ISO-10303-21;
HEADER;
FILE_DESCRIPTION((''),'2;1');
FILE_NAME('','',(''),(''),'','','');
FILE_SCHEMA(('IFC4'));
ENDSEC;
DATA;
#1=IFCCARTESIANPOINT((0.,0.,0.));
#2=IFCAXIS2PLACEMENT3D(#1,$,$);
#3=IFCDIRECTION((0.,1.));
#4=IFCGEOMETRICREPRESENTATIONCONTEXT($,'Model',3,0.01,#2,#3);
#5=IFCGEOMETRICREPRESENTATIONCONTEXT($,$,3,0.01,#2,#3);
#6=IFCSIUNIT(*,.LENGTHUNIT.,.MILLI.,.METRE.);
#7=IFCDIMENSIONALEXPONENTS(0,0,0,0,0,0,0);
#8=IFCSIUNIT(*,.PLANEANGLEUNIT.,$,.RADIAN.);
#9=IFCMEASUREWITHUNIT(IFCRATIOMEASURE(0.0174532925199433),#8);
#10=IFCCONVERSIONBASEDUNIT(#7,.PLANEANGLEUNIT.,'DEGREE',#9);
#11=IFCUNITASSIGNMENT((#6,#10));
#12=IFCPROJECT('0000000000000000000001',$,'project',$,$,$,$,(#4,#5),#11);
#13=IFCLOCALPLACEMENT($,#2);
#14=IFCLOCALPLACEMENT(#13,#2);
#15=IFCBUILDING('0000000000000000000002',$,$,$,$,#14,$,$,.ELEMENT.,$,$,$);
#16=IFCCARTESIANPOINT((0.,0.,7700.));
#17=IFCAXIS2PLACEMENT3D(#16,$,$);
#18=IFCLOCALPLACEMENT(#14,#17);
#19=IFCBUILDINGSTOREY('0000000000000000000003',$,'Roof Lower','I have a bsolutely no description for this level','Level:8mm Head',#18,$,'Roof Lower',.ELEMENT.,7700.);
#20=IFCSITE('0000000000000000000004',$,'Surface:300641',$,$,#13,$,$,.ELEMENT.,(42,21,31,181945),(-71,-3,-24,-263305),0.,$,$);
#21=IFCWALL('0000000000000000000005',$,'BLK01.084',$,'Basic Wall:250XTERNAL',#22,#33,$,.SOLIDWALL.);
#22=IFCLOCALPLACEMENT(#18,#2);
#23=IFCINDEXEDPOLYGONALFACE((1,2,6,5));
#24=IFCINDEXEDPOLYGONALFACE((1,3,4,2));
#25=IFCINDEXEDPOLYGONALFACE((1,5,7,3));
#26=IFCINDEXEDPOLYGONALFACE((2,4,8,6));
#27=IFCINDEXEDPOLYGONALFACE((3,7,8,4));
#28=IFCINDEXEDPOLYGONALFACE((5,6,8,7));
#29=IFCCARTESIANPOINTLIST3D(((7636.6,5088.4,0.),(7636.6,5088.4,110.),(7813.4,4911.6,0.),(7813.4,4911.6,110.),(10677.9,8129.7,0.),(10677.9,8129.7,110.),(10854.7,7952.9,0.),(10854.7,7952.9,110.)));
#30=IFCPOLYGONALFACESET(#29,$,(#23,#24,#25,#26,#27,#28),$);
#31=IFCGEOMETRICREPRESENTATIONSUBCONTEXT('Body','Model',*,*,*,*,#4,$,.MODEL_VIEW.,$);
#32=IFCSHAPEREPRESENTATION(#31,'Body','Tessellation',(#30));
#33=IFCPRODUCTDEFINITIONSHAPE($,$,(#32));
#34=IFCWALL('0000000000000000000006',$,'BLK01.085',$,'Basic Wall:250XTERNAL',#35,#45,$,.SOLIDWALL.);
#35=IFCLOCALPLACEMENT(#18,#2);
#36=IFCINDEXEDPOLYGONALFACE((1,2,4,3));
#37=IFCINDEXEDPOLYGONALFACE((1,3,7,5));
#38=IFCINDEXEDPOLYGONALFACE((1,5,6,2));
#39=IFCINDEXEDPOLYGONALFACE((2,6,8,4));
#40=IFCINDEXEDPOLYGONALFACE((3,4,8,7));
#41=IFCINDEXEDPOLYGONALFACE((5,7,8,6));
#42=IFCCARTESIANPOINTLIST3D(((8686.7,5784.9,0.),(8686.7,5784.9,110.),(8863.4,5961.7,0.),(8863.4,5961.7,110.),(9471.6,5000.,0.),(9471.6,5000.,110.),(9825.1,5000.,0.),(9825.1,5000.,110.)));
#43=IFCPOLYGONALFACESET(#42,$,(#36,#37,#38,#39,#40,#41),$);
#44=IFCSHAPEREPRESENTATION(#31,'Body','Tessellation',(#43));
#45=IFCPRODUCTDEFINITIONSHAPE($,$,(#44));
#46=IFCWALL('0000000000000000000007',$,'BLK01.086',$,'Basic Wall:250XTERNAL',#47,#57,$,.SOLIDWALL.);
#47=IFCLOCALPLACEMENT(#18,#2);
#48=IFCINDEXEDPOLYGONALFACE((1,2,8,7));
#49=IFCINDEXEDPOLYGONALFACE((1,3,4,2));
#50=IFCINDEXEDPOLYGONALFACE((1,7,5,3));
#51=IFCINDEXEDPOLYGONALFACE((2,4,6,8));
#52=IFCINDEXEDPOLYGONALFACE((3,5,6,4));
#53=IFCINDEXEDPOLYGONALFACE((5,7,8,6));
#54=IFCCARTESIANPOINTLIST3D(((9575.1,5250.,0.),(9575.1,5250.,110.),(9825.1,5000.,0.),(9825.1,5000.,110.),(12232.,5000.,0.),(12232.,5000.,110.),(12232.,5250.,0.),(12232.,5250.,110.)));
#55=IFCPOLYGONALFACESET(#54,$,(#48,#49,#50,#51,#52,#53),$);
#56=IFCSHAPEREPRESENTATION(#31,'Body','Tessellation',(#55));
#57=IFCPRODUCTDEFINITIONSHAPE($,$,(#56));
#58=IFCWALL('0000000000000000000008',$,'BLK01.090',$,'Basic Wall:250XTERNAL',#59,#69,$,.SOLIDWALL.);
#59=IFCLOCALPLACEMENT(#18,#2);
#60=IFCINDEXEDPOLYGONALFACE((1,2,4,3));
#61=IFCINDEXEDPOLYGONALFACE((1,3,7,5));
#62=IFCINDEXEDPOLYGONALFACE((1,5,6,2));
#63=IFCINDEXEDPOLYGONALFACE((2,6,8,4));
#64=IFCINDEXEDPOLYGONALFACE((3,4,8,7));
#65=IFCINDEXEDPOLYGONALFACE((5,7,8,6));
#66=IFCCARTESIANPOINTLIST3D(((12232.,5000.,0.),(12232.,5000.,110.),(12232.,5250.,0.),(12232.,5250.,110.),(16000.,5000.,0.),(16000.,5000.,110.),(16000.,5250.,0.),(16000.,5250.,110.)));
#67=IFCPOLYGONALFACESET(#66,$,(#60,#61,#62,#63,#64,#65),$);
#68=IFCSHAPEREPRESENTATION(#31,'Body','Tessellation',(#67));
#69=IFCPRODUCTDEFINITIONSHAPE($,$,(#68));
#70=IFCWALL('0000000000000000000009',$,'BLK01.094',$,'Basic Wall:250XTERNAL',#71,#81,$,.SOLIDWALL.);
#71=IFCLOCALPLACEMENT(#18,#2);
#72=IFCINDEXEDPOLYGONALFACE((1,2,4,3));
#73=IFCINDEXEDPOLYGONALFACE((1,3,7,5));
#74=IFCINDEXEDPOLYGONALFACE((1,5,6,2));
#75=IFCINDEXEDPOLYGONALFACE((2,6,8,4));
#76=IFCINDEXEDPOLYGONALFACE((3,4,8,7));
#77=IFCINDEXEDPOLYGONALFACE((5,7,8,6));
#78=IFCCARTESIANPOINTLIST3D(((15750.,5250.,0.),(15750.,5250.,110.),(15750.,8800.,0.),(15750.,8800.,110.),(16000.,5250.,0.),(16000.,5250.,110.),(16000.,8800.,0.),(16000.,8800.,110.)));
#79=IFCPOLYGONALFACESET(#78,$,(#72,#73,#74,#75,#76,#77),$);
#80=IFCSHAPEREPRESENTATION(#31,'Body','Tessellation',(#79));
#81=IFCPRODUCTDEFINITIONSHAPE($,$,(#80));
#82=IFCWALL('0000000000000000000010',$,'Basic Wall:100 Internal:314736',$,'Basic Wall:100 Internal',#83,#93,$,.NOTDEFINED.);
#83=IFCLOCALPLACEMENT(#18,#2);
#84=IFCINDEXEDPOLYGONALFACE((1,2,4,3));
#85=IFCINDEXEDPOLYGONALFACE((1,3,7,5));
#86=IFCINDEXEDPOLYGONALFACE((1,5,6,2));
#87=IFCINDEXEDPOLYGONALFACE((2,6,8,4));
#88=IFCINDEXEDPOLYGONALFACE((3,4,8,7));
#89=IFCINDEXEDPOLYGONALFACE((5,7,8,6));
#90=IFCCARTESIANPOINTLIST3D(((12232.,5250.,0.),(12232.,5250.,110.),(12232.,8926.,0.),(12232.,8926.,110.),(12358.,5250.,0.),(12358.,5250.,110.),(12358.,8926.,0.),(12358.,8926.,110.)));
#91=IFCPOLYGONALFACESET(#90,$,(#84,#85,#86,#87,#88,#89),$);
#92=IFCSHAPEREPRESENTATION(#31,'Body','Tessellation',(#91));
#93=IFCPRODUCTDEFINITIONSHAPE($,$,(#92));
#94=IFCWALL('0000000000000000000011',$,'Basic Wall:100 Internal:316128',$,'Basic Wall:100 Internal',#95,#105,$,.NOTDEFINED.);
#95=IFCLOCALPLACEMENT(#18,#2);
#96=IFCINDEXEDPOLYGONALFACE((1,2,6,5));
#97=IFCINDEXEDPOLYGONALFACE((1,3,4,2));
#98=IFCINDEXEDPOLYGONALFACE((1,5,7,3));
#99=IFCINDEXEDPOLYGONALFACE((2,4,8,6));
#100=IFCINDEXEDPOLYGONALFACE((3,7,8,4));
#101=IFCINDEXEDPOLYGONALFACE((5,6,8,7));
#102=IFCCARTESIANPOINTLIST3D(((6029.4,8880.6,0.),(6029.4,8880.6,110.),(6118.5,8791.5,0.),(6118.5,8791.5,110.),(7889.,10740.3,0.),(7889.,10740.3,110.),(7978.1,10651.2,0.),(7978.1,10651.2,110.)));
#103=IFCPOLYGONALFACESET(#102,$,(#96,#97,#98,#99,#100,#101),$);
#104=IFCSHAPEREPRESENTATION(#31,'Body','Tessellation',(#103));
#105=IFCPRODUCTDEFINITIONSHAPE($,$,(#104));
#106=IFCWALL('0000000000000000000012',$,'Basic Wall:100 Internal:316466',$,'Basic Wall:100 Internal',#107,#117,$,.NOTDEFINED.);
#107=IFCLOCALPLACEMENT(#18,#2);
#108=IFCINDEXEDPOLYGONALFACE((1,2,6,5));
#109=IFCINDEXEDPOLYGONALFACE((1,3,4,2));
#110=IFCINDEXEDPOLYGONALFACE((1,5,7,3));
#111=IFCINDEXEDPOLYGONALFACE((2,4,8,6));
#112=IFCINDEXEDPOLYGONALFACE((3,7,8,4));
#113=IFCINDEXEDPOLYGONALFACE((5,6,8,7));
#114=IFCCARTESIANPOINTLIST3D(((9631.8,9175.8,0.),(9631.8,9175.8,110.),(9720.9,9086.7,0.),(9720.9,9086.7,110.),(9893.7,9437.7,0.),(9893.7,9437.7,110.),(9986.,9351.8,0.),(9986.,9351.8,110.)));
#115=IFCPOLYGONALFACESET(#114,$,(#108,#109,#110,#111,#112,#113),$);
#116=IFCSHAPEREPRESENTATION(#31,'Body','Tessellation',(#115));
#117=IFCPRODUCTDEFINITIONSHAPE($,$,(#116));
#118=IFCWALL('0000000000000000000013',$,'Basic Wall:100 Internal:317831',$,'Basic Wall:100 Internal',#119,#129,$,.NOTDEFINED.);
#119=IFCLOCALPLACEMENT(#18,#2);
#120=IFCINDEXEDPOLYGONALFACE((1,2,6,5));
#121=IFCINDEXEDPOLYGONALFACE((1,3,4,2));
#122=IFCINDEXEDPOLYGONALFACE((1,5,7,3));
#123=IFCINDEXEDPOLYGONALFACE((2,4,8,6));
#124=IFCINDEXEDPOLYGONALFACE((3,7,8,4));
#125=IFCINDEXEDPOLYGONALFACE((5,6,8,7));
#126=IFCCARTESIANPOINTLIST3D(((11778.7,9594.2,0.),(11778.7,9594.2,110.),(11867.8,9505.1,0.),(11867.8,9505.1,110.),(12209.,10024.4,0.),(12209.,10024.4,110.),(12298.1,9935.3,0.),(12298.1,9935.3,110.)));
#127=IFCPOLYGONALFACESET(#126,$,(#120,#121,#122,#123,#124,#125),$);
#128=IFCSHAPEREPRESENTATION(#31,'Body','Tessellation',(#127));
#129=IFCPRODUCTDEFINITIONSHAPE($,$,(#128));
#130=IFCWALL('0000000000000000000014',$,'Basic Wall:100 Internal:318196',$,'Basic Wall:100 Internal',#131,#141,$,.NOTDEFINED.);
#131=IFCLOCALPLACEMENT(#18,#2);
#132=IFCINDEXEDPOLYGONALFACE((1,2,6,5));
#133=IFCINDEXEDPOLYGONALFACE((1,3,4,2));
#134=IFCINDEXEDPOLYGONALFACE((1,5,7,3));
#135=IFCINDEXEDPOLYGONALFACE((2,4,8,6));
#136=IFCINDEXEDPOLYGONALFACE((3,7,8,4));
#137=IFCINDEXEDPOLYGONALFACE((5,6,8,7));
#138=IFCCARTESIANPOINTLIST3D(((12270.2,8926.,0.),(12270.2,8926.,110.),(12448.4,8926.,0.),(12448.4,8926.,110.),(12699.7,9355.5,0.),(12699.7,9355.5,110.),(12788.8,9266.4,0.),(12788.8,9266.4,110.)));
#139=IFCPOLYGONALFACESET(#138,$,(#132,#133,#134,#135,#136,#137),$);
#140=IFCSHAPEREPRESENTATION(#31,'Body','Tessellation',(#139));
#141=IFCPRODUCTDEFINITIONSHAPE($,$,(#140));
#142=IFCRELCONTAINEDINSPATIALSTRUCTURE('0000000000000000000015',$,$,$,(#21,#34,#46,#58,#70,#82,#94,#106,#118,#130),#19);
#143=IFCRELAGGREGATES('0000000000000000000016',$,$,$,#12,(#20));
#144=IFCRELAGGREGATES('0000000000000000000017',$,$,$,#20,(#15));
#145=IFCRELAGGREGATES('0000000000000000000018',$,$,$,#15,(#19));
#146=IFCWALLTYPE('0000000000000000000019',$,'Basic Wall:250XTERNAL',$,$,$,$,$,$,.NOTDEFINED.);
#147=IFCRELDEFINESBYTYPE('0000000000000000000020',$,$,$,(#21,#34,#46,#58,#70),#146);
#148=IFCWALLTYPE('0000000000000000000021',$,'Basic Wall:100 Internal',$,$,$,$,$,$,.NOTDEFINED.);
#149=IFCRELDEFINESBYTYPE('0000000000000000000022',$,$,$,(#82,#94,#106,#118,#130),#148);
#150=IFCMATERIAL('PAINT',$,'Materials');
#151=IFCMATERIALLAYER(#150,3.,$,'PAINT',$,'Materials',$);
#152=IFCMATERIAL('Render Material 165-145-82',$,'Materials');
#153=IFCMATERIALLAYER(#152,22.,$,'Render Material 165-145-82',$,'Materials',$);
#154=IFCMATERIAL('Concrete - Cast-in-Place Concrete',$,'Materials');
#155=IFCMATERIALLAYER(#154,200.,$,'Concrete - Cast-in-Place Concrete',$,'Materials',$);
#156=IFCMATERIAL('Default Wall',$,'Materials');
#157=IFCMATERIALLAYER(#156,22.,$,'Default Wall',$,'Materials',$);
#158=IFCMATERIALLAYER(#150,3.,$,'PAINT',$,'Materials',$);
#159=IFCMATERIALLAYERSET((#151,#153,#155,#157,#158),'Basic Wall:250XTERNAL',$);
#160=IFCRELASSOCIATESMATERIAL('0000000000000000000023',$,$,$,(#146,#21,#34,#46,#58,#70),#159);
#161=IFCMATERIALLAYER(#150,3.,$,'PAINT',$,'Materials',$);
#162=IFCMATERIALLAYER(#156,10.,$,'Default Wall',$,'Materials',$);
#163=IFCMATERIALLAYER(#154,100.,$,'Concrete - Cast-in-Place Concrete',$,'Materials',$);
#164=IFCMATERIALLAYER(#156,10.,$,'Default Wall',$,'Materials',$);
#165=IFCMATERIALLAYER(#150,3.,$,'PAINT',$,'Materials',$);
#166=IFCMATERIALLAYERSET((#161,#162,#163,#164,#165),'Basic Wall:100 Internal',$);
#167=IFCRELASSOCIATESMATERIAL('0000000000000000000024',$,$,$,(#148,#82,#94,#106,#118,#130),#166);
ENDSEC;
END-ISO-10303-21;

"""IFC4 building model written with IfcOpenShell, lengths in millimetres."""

from ifc_helpers import new_model, entity, si_unit, converted_unit, direction, frame, frame_2d, origin, place, context, subcontext, project, spatial, polyline, rectangle, outline, extrude, clip, halfspace, bounded_halfspace, material, layer, layer_set, layer_usage, type_object, element, save


model = new_model("IFC4")

# Units and contexts
model_context = context("Model", 3, precision=0.01, world=origin(), true_north=direction((0.0, 1.0)))
context_of_model = context(None, 3, precision=0.01, world=origin(), true_north=direction((0.0, 1.0)))
body_context = subcontext(model_context, "Body", "Model", "MODEL_VIEW")
ifc_project = project(units=[si_unit("LENGTHUNIT", "METRE", prefix="MILLI"), converted_unit("PLANEANGLEUNIT", "DEGREE", entity("IfcRatioMeasure", 0.0174532925199433), si_unit("PLANEANGLEUNIT", "RADIAN"), dimensions=[0, 0, 0, 0, 0, 0, 0])], contexts=[model_context, context_of_model])

# Site, building, storey
site_placement = place(None, origin())
site = spatial("IfcSite", under=ifc_project, at=site_placement, Name="Surface:300641", CompositionType="ELEMENT", RefLatitude=(42, 21, 31, 181945), RefLongitude=(-71, -3, -24, -263305), RefElevation=0.0)
building_placement = place(site_placement, origin())
building = spatial("IfcBuilding", under=site, at=building_placement, CompositionType="ELEMENT")
storey_placement = place(building_placement, frame((0.0, 0.0, 7700.0)))
storey = spatial("IfcBuildingStorey", under=building, at=storey_placement, Name="Roof Lower", Description="I have a bsolutely no description for this level", ObjectType="Level:8mm Head", LongName="Roof Lower", CompositionType="ELEMENT", Elevation=7700.0)

# Shared definitions
ifc_material_1 = material(Name="Concrete - Cast-in-Place Concrete", Category="Materials")

# Walls
ifc_material_2 = material(Name="PAINT", Category="Materials")
ifc_layer_1 = layer(ifc_material_2, 3.0, Name="PAINT", Category="Materials")
ifc_material_3 = material(Name="Render Material 165-145-82", Category="Materials")
ifc_layer_2 = layer(ifc_material_3, 22.0, Name="Render Material 165-145-82", Category="Materials")
ifc_layer_3 = layer(ifc_material_1, 200.0, Name="Concrete - Cast-in-Place Concrete", Category="Materials")
ifc_material_4 = material(Name="Default Wall", Category="Materials")
ifc_layer_4 = layer(ifc_material_4, 22.0, Name="Default Wall", Category="Materials")
ifc_layer_5 = layer(ifc_material_2, 3.0, Name="PAINT", Category="Materials")
ifc_layer_set_1 = layer_set([ifc_layer_1, ifc_layer_2, ifc_layer_3, ifc_layer_4, ifc_layer_5], Name="Basic Wall:250XTERNAL")
ifc_layer_usage_1 = layer_usage(ifc_layer_set_1, "AXIS2", "NEGATIVE", 125.0)
wall_type_1 = type_object("IfcWallType", Name="Basic Wall:250XTERNAL", PredefinedType="NOTDEFINED", material=ifc_layer_set_1)
wall_1_placement = place(storey_placement, frame((7725.0, 5000.0, 0.0), z_axis=(0.0, 0.0, 1.0), x_axis=(0.707107, 0.707107, 0.0)))
element("IfcWall", 1, at=wall_1_placement, inside=storey, type_object=wall_type_1, material=ifc_layer_usage_1, Name="BLK01.084", ObjectType="Basic Wall:250XTERNAL", PredefinedType="SOLIDWALL", context=body_context, shape_type="Clipping", body=[
    clip(clip(extrude(rectangle(XDim=4301.0, YDim=250.0, at=frame_2d((2150.5, 0.0), x_axis=(-1.0, 0.0))), origin(), (0.0, 0.0, 1.0), 110.0), bounded_halfspace(frame((0.0, -125.0, 110.0), z_axis=(0.0, 0.0, -1.0), x_axis=(0.707107, -0.707107, 0.0)), True, frame((0.0, -125.0, 110.0)), polyline([(0.0, 0.0), (1235.0, 0.0), (1485.0, 0.0), (3527.0, 0.0), (3653.0, 0.0), (4301.0, 0.0), (4301.0, 250.0), (4175.0, 250.0), (0.0, 250.0), (0.0, 0.0)]))), halfspace(frame((0.0, 0.0, -3500.0)), True)),
])
ifc_layer_usage_2 = layer_usage(ifc_layer_set_1, "AXIS2", "NEGATIVE", 125.0)
wall_2_placement = place(storey_placement, frame((8775.1, 5873.3, 0.0), z_axis=(0.0, 0.0, 1.0), x_axis=(0.707107, -0.707107, 0.0)))
element("IfcWall", 2, at=wall_2_placement, inside=storey, type_object=wall_type_1, material=ifc_layer_usage_2, Name="BLK01.085", ObjectType="Basic Wall:250XTERNAL", PredefinedType="SOLIDWALL", context=body_context, shape_type="Clipping", body=[
    clip(clip(extrude(outline(polyline([(1110.0, -125.0), (1360.0, 125.0), (1006.4, 125.0), (0.0, 125.0), (0.0, -125.0), (1110.0, -125.0)])), origin(), (0.0, 0.0, 1.0), 110.0), bounded_halfspace(frame((0.0, -125.0, 110.0), z_axis=(0.0, 0.0, -1.0), x_axis=(0.707107, 0.707107, 0.0)), True, frame((0.0, -125.0, 110.0)), polyline([(0.0, 0.0), (1110.0, 0.0), (1360.0, 250.0), (1006.4, 250.0), (0.0, 250.0), (0.0, 0.0)]))), halfspace(frame((0.0, 0.0, -3500.0)), True)),
])
ifc_layer_usage_3 = layer_usage(ifc_layer_set_1, "AXIS2", "NEGATIVE", 125.0)
wall_3_placement = place(storey_placement, frame((9575.1, 5125.0, 0.0)))
element("IfcWall", 3, at=wall_3_placement, inside=storey, type_object=wall_type_1, material=ifc_layer_usage_3, Name="BLK01.086", ObjectType="Basic Wall:250XTERNAL", PredefinedType="SOLIDWALL", context=body_context, shape_type="Clipping", body=[
    clip(clip(extrude(outline(polyline([(2656.9, -125.0), (2656.9, 125.0), (0.0, 125.0), (250.0, -125.0), (2656.9, -125.0)])), origin(), (0.0, 0.0, 1.0), 110.0), bounded_halfspace(frame((2656.9, 125.0, 110.0), z_axis=(0.0, 0.0, -1.0), x_axis=(1.0, 0.0, 0.0)), True, frame((2656.9, 125.0, 110.0)), polyline([(0.0, 0.0), (-2656.9, 0.0), (-2406.9, -250.0), (0.0, -250.0), (0.0, 0.0)]))), halfspace(frame((0.0, 0.0, -3500.0)), True)),
])
ifc_layer_usage_4 = layer_usage(ifc_layer_set_1, "AXIS2", "NEGATIVE", 125.0)
wall_4_placement = place(storey_placement, frame((12232.0, 5125.0, 0.0)))
element("IfcWall", 4, at=wall_4_placement, inside=storey, type_object=wall_type_1, material=ifc_layer_usage_4, Name="BLK01.090", ObjectType="Basic Wall:250XTERNAL", PredefinedType="SOLIDWALL", context=body_context, shape_type="Clipping", body=[
    clip(clip(extrude(rectangle(XDim=3768.0, YDim=250.0, at=frame_2d((1884.0, 0.0), x_axis=(-1.0, 0.0))), origin(), (0.0, 0.0, 1.0), 110.0), bounded_halfspace(frame((3768.0, 125.0, 110.0), z_axis=(0.0, 0.0, -1.0), x_axis=(1.0, 0.0, 0.0)), True, frame((3768.0, 125.0, 110.0)), polyline([(0.0, 0.0), (-250.0, 0.0), (-3642.0, 0.0), (-3768.0, 0.0), (-3768.0, -250.0), (0.0, -250.0), (0.0, 0.0)]))), halfspace(frame((0.0, 0.0, -3500.0)), True)),
])
ifc_layer_usage_5 = layer_usage(ifc_layer_set_1, "AXIS2", "POSITIVE", -125.0)
wall_5_placement = place(storey_placement, frame((15875.0, 5250.0, 0.0), z_axis=(0.0, 0.0, 1.0), x_axis=(0.0, 1.0, 0.0)))
element("IfcWall", 5, at=wall_5_placement, inside=storey, type_object=wall_type_1, material=ifc_layer_usage_5, Name="BLK01.094", ObjectType="Basic Wall:250XTERNAL", PredefinedType="SOLIDWALL", context=body_context, shape_type="Clipping", body=[
    clip(clip(extrude(rectangle(XDim=3550.0, YDim=250.0, at=frame_2d((1775.0, 0.0), x_axis=(-1.0, 0.0))), origin(), (0.0, 0.0, 1.0), 110.0), bounded_halfspace(frame((0.0, -125.0, 110.0), z_axis=(0.0, 0.0, -1.0), x_axis=(0.0, -1.0, 0.0)), True, frame((0.0, -125.0, 110.0)), polyline([(0.0, 0.0), (3550.0, 0.0), (3550.0, 190.0), (3550.0, 250.0), (0.0, 250.0), (0.0, 0.0)]))), halfspace(frame((0.0, 0.0, -3500.0)), True)),
])
ifc_layer_6 = layer(ifc_material_2, 3.0, Name="PAINT", Category="Materials")
ifc_layer_7 = layer(ifc_material_4, 10.0, Name="Default Wall", Category="Materials")
ifc_layer_8 = layer(ifc_material_1, 100.0, Name="Concrete - Cast-in-Place Concrete", Category="Materials")
ifc_layer_9 = layer(ifc_material_4, 10.0, Name="Default Wall", Category="Materials")
ifc_layer_10 = layer(ifc_material_2, 3.0, Name="PAINT", Category="Materials")
ifc_layer_set_2 = layer_set([ifc_layer_6, ifc_layer_7, ifc_layer_8, ifc_layer_9, ifc_layer_10], Name="Basic Wall:100 Internal")
ifc_layer_usage_6 = layer_usage(ifc_layer_set_2, "AXIS2", "NEGATIVE", 63.0)
wall_type_2 = type_object("IfcWallType", Name="Basic Wall:100 Internal", PredefinedType="NOTDEFINED", material=ifc_layer_set_2)
wall_6_placement = place(storey_placement, frame((12295.0, 5250.0, 0.0), z_axis=(0.0, 0.0, 1.0), x_axis=(0.0, 1.0, 0.0)))
element("IfcWall", 6, at=wall_6_placement, inside=storey, type_object=wall_type_2, material=ifc_layer_usage_6, Name="Basic Wall:100 Internal:314736", ObjectType="Basic Wall:100 Internal", PredefinedType="NOTDEFINED", context=body_context, shape_type="Clipping", body=[
    clip(clip(extrude(rectangle(XDim=3676.0, YDim=126.0, at=frame_2d((1838.0, 0.0), x_axis=(-1.0, 0.0))), origin(), (0.0, 0.0, 1.0), 110.0), bounded_halfspace(frame((0.0, -63.0, 110.0), z_axis=(0.0, 0.0, -1.0), x_axis=(0.0, -1.0, 0.0)), True, frame((0.0, -63.0, 110.0)), polyline([(0.0, 0.0), (3550.0, 0.0), (3676.0, 0.0), (3676.0, 87.8), (3676.0, 126.0), (1485.3, 126.0), (1359.3, 126.0), (0.0, 126.0), (0.0, 0.0)]))), halfspace(frame((0.0, 0.0, -3500.0)), True)),
])
ifc_layer_usage_7 = layer_usage(ifc_layer_set_2, "AXIS2", "NEGATIVE", 63.0)
wall_7_placement = place(storey_placement, frame((6073.9, 8836.1, 0.0), z_axis=(0.0, 0.0, 1.0), x_axis=(0.707107, 0.707107, 0.0)))
element("IfcWall", 7, at=wall_7_placement, inside=storey, type_object=wall_type_2, material=ifc_layer_usage_7, Name="Basic Wall:100 Internal:316128", ObjectType="Basic Wall:100 Internal", PredefinedType="NOTDEFINED", context=body_context, shape_type="Clipping", body=[
    clip(clip(extrude(rectangle(XDim=2630.0, YDim=126.0, at=frame_2d((1315.0, 0.0), x_axis=(-1.0, 0.0))), origin(), (0.0, 0.0, 1.0), 110.0), bounded_halfspace(frame((0.0, -63.0, 110.0), z_axis=(0.0, 0.0, -1.0), x_axis=(0.707107, -0.707107, 0.0)), True, frame((0.0, -63.0, 110.0)), polyline([(0.0, 0.0), (2630.0, 0.0), (2630.0, 126.0), (0.0, 126.0), (0.0, 0.0)]))), halfspace(frame((0.0, 0.0, -3500.0)), True)),
])
ifc_layer_usage_8 = layer_usage(ifc_layer_set_2, "AXIS2", "NEGATIVE", 63.0)
wall_8_placement = place(storey_placement, frame((9941.4, 9396.3, 0.0), z_axis=(0.0, 0.0, 1.0), x_axis=(-0.707107, -0.707107, 0.0)))
element("IfcWall", 8, at=wall_8_placement, inside=storey, type_object=wall_type_2, material=ifc_layer_usage_8, Name="Basic Wall:100 Internal:316466", ObjectType="Basic Wall:100 Internal", PredefinedType="NOTDEFINED", context=body_context, shape_type="Clipping", body=[
    clip(clip(extrude(outline(polyline([(374.9, -63.0), (374.9, 63.0), (0.0, 63.0), (4.4, -63.0), (374.9, -63.0)])), origin(), (0.0, 0.0, 1.0), 110.0), bounded_halfspace(frame((4.4, -63.0, 110.0), z_axis=(0.0, 0.0, -1.0), x_axis=(-0.707107, 0.707107, 0.0)), True, frame((4.4, -63.0, 110.0)), polyline([(0.0, 0.0), (370.5, 0.0), (370.5, 126.0), (-4.4, 126.0), (0.0, 0.0)]))), halfspace(frame((0.0, 0.0, -3500.0)), True)),
])
ifc_layer_usage_9 = layer_usage(ifc_layer_set_2, "AXIS2", "NEGATIVE", 63.0)
wall_9_placement = place(storey_placement, frame((11823.3, 9549.6, 0.0), z_axis=(0.0, 0.0, 1.0), x_axis=(0.707107, 0.707107, 0.0)))
element("IfcWall", 9, at=wall_9_placement, inside=storey, type_object=wall_type_2, material=ifc_layer_usage_9, Name="Basic Wall:100 Internal:317831", ObjectType="Basic Wall:100 Internal", PredefinedType="NOTDEFINED", context=body_context, shape_type="Clipping", body=[
    clip(clip(extrude(rectangle(XDim=608.4, YDim=126.0, at=frame_2d((304.2, 0.0), x_axis=(-1.0, 0.0))), origin(), (0.0, 0.0, 1.0), 110.0), bounded_halfspace(frame((0.0, -63.0, 110.0), z_axis=(0.0, 0.0, -1.0), x_axis=(0.707107, -0.707107, 0.0)), True, frame((0.0, -63.0, 110.0)), polyline([(0.0, 0.0), (482.4, 0.0), (608.4, 0.0), (608.4, 126.0), (0.0, 126.0), (0.0, 0.0)]))), halfspace(frame((0.0, 0.0, -3500.0)), True)),
])
ifc_layer_usage_10 = layer_usage(ifc_layer_set_2, "AXIS2", "NEGATIVE", 63.0)
wall_10_placement = place(storey_placement, frame((12744.2, 9310.9, 0.0), z_axis=(0.0, 0.0, 1.0), x_axis=(-0.707107, -0.707107, 0.0)))
element("IfcWall", 10, at=wall_10_placement, inside=storey, type_object=wall_type_2, material=ifc_layer_usage_10, Name="Basic Wall:100 Internal:318196", ObjectType="Basic Wall:100 Internal", PredefinedType="NOTDEFINED", context=body_context, shape_type="Clipping", body=[
    clip(clip(extrude(outline(polyline([(607.4, -63.0), (545.3, -0.9), (481.4, 63.0), (0.0, 63.0), (0.0, -63.0), (607.4, -63.0)])), origin(), (0.0, 0.0, 1.0), 110.0), bounded_halfspace(frame((0.0, -63.0, 110.0), z_axis=(0.0, 0.0, -1.0), x_axis=(-0.707107, 0.707107, 0.0)), True, frame((0.0, -63.0, 110.0)), polyline([(0.0, 0.0), (607.4, 0.0), (545.3, 62.1), (481.4, 126.0), (0.0, 126.0), (0.0, 0.0)]))), halfspace(frame((0.0, 0.0, -3500.0)), True)),
])

save(model, "model.ifc")
